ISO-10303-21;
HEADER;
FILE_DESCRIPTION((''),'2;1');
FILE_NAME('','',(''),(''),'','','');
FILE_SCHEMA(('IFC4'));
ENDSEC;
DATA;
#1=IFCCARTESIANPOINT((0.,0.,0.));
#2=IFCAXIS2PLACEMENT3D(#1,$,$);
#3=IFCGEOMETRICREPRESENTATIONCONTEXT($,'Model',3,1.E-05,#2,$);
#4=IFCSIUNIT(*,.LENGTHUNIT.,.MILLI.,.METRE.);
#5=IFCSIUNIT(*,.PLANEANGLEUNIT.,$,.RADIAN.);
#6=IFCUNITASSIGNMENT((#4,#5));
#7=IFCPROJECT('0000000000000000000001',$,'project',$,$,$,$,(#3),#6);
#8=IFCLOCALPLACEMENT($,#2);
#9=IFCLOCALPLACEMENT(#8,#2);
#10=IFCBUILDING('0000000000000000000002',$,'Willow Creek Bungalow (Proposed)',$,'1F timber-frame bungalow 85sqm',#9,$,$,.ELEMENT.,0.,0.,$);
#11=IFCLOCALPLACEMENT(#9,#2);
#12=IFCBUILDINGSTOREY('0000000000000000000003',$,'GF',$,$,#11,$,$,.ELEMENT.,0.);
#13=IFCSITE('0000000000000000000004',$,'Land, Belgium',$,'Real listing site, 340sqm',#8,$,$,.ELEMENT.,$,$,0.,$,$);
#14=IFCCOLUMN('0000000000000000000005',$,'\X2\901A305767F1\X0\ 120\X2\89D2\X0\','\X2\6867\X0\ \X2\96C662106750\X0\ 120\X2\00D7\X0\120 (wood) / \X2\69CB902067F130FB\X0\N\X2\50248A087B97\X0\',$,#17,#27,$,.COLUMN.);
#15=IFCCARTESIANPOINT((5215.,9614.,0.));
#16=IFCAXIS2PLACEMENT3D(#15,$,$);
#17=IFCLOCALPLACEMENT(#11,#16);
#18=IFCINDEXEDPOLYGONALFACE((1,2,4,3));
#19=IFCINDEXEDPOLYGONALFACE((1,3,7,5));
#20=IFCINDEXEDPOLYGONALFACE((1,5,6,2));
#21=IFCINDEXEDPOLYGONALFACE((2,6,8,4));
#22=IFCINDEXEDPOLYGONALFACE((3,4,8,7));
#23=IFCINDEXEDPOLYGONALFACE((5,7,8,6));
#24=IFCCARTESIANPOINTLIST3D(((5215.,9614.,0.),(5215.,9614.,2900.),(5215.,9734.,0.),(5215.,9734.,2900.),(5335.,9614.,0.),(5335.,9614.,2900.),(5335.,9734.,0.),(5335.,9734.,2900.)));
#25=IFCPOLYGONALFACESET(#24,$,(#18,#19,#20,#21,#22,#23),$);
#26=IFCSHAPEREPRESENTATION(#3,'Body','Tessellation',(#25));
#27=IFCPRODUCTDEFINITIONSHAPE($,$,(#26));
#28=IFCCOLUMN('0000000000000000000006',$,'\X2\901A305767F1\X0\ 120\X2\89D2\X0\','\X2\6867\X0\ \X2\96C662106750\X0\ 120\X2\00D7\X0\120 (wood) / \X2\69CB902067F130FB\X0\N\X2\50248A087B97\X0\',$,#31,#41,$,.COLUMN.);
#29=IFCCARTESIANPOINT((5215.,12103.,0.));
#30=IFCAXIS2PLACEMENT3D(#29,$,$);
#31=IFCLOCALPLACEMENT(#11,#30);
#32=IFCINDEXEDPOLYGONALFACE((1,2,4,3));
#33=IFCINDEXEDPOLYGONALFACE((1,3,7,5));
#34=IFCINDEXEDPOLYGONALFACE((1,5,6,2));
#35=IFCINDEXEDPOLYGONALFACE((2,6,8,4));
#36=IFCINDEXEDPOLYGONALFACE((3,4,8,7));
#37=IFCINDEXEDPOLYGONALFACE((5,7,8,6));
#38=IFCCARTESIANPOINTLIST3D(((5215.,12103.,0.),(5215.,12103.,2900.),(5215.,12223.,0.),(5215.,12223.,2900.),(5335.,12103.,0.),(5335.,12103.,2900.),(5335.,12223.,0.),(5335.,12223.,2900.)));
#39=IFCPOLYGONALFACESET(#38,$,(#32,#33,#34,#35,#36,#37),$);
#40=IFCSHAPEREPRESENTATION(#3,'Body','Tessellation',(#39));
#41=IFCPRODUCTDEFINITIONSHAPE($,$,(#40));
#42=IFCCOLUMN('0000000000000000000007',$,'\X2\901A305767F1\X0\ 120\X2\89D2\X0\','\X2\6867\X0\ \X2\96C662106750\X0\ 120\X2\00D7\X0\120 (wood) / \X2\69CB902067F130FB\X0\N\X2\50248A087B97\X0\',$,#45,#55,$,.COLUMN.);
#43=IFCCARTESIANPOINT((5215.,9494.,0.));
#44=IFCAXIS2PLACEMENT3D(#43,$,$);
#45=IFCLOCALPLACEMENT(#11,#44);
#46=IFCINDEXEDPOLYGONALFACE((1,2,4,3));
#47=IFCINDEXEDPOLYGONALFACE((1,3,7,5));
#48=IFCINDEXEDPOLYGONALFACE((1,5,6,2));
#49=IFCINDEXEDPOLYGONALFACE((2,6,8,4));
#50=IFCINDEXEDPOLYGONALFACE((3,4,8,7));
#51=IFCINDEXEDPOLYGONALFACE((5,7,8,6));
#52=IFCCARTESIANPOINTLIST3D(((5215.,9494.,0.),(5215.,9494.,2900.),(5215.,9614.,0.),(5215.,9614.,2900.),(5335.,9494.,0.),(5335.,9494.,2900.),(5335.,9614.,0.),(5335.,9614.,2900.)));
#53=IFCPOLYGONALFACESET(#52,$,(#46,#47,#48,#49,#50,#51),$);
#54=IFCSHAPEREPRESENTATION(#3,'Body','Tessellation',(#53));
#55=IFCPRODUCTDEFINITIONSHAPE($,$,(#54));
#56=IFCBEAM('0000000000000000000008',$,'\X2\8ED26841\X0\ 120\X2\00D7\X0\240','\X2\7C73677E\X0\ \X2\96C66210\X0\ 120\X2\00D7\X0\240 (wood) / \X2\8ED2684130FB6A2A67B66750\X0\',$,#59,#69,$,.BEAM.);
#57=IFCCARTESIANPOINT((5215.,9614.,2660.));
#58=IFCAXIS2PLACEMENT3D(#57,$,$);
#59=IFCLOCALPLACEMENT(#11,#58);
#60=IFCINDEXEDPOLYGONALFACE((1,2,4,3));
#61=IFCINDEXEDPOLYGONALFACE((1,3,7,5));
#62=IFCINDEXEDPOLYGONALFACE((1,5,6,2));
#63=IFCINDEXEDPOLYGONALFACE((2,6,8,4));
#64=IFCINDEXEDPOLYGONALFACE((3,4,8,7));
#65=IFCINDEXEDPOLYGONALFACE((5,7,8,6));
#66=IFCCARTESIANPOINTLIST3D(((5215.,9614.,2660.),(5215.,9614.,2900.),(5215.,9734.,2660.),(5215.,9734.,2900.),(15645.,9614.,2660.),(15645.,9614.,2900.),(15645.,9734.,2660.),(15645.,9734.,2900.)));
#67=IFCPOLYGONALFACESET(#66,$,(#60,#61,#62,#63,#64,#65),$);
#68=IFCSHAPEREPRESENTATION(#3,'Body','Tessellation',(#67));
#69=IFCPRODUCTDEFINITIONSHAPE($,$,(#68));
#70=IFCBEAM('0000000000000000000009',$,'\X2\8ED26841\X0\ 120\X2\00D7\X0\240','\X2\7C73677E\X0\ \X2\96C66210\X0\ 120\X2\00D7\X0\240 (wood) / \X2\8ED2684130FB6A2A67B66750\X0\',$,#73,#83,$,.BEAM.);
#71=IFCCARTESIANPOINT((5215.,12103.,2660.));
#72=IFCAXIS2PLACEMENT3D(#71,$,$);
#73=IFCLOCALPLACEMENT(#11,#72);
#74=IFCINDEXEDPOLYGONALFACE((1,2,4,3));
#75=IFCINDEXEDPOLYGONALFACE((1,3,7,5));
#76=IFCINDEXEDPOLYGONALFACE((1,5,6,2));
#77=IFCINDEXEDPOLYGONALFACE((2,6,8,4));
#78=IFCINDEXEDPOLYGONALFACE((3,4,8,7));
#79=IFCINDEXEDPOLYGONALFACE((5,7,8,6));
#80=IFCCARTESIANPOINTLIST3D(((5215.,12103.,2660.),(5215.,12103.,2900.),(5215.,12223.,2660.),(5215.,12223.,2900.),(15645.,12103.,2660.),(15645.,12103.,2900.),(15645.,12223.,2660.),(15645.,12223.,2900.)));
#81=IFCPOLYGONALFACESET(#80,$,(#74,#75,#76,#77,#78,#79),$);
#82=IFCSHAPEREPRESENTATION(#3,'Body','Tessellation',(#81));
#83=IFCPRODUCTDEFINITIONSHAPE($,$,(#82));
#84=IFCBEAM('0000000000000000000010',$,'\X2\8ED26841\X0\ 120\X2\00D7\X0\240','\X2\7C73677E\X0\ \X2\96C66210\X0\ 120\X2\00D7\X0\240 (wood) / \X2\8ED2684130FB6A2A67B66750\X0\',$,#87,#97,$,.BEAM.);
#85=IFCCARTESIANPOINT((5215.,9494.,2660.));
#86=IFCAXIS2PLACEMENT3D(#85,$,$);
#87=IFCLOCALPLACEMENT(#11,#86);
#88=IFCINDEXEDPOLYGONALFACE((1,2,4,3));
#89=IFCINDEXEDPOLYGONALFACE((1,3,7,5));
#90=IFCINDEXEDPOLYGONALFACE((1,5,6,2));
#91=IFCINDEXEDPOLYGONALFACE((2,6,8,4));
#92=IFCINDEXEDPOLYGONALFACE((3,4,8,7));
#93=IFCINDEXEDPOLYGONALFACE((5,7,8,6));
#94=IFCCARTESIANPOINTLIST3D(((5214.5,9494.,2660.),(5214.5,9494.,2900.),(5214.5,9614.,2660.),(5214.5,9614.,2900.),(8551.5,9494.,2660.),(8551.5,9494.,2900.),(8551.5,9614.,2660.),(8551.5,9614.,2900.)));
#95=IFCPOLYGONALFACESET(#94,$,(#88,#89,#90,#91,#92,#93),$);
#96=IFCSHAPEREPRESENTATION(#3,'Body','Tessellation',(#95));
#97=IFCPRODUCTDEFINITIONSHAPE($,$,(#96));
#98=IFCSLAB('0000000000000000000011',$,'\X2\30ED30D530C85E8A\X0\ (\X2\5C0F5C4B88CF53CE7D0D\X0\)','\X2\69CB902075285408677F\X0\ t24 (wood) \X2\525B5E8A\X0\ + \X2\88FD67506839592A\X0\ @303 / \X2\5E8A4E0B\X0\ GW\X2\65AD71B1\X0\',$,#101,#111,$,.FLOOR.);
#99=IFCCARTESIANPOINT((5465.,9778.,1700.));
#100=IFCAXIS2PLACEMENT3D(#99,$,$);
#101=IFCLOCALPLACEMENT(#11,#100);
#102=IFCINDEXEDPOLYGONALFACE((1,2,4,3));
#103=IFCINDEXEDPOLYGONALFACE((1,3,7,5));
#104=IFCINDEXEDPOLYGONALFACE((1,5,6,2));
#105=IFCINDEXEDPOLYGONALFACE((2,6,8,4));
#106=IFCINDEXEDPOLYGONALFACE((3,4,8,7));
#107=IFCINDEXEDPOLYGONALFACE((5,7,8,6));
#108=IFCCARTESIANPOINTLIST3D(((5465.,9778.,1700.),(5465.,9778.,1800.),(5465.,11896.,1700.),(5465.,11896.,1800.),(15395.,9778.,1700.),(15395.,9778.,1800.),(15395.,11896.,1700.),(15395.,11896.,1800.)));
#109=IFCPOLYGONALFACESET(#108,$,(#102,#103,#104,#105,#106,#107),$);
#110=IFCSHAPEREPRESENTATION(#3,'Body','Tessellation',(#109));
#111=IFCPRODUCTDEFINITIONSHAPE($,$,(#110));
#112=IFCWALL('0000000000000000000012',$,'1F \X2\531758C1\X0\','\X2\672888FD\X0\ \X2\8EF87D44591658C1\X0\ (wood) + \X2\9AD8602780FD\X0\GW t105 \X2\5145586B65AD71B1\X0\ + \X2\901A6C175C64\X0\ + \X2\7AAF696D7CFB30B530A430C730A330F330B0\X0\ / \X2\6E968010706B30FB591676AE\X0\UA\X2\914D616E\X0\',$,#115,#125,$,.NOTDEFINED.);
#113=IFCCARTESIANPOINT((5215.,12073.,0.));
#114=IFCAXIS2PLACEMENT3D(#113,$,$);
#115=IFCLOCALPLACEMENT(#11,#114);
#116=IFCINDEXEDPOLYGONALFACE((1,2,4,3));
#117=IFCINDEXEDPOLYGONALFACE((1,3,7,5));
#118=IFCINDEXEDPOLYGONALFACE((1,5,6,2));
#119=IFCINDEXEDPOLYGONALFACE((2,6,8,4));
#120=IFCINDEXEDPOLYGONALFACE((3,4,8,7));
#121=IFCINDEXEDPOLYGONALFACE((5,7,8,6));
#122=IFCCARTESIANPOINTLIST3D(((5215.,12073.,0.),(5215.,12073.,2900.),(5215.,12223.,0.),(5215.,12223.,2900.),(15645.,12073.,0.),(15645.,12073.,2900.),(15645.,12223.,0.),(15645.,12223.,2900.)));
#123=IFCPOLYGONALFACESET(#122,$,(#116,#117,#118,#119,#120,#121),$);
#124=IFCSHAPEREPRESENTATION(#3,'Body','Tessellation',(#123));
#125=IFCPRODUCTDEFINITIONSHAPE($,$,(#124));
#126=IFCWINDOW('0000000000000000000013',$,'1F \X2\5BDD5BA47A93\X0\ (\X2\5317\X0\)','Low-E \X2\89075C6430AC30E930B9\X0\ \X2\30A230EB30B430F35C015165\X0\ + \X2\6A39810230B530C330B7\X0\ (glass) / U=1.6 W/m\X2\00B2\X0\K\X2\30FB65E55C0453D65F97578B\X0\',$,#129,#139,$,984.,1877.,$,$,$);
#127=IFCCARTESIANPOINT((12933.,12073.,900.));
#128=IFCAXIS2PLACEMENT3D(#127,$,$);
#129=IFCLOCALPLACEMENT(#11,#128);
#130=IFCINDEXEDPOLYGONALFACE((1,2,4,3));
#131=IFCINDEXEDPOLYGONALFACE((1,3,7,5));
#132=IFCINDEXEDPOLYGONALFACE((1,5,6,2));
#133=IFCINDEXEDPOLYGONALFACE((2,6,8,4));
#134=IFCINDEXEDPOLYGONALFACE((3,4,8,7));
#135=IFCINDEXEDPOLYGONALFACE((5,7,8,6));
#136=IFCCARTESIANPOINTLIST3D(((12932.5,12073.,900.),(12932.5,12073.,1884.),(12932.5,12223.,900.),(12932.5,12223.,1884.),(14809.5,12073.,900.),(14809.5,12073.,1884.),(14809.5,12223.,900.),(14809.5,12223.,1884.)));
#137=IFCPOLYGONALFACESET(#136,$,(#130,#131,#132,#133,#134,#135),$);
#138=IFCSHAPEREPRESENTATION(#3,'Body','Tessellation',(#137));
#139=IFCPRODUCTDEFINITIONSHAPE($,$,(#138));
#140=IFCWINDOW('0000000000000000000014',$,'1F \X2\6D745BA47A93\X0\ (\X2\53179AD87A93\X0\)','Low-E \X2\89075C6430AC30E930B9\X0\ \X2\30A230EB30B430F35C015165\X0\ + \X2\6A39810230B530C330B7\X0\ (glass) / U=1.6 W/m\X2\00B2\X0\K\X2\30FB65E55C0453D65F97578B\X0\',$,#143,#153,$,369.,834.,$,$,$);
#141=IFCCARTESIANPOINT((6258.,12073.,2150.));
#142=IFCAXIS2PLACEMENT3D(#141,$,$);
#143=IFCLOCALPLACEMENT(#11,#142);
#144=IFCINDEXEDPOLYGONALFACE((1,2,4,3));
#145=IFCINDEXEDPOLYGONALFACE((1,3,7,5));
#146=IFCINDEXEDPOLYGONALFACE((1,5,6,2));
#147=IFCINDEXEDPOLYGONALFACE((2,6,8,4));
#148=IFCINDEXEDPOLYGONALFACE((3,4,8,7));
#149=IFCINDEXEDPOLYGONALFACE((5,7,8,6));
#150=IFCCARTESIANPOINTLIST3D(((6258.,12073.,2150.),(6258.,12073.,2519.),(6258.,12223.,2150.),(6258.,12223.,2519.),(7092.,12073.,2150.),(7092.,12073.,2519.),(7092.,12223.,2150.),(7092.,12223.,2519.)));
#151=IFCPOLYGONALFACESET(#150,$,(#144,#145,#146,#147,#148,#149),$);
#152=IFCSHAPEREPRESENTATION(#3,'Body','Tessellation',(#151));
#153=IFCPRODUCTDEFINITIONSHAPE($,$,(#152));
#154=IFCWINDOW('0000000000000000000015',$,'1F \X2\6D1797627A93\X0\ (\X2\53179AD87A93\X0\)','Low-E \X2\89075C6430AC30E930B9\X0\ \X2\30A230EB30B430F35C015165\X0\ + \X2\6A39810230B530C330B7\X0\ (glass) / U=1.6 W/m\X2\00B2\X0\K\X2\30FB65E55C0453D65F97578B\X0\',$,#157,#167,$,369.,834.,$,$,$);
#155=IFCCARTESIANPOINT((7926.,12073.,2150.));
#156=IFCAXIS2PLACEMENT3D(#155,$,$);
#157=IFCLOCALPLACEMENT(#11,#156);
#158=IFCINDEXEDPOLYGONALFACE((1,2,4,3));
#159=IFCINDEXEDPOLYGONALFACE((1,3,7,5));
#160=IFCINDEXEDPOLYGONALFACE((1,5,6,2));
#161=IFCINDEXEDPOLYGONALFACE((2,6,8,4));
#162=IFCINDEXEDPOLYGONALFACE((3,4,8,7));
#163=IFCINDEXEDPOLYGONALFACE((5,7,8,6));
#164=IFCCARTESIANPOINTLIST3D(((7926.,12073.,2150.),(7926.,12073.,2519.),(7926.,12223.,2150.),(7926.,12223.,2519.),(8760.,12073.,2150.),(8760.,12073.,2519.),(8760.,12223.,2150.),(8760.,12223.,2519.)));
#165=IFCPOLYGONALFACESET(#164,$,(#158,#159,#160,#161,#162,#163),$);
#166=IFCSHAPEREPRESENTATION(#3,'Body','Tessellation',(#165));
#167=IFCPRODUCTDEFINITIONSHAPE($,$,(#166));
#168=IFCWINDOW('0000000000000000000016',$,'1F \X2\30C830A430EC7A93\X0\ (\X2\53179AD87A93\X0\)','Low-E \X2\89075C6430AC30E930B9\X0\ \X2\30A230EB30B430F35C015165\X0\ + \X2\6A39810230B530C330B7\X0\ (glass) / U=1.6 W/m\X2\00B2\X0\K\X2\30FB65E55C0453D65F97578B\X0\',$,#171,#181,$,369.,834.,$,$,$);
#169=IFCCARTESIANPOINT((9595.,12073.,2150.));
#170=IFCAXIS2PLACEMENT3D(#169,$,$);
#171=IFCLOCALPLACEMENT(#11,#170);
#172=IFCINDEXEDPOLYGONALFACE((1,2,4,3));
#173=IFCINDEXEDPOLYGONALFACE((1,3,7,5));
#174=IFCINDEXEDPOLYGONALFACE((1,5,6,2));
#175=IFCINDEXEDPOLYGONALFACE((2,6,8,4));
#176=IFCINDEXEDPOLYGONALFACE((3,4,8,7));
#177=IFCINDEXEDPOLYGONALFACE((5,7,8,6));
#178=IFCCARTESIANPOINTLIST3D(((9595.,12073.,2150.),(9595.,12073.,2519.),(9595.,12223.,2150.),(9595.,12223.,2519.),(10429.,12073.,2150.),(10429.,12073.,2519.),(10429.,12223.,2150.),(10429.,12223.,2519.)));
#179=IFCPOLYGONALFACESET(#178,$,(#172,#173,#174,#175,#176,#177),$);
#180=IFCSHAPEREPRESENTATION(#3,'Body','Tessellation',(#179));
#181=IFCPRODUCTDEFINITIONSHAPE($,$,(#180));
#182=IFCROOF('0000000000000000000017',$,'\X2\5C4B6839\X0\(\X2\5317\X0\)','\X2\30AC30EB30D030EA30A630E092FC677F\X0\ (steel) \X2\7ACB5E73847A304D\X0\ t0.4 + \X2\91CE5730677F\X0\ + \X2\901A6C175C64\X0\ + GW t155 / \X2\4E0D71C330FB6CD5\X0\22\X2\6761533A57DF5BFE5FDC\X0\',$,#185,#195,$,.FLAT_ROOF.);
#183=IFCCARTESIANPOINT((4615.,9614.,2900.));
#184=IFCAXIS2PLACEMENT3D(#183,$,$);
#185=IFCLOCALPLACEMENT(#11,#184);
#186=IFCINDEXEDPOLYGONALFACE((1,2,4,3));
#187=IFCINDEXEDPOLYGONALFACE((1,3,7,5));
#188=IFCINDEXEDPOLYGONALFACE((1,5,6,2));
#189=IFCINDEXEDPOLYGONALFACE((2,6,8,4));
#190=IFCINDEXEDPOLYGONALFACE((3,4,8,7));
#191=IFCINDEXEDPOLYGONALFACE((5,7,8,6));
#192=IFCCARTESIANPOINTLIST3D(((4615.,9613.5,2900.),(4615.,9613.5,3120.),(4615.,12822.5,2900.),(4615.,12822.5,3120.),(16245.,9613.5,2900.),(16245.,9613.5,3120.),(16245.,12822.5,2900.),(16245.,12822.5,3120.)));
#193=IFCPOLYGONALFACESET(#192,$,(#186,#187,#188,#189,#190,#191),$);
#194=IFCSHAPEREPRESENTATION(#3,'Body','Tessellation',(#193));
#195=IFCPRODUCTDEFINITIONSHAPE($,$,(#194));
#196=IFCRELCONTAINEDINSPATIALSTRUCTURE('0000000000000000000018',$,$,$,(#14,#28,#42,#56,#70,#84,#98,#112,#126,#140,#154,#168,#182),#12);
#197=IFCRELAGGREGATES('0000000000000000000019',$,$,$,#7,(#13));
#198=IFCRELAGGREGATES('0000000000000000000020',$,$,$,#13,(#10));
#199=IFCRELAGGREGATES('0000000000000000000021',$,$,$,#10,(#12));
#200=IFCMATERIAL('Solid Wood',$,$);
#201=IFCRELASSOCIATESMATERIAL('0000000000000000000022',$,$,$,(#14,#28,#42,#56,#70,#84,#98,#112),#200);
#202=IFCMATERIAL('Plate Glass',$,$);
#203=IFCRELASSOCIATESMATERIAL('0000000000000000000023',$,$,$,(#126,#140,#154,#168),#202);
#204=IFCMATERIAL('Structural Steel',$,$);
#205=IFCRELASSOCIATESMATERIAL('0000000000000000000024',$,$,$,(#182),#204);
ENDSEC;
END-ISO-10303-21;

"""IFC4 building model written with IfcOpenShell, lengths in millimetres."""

from ifc_helpers import new_model, si_unit, frame, frame_2d, origin, place, context, project, spatial, rectangle, extrude, material, element, fill, save


model = new_model("IFC4")

# Units and contexts
model_context = context("Model", 3, precision=1e-05, world=origin())
ifc_project = project(units=[si_unit("LENGTHUNIT", "METRE", prefix="MILLI"), si_unit("PLANEANGLEUNIT", "RADIAN")], contexts=[model_context])

# Site, building, storey
site_placement = place(None, origin())
site = spatial("IfcSite", under=ifc_project, at=site_placement, Name="Land, Belgium", ObjectType="Real listing site, 340sqm", CompositionType="ELEMENT", RefElevation=0.0)
building_placement = place(site_placement, origin())
building = spatial("IfcBuilding", under=site, at=building_placement, Name="Willow Creek Bungalow (Proposed)", ObjectType="1F timber-frame bungalow 85sqm", CompositionType="ELEMENT", ElevationOfRefHeight=0.0, ElevationOfTerrain=0.0)
storey_placement = place(building_placement, origin())
storey = spatial("IfcBuildingStorey", under=building, at=storey_placement, Name="GF", CompositionType="ELEMENT", Elevation=0.0)

# Columns
ifc_material_1 = material(Name="Solid Wood")
column_1_placement = place(storey_placement, frame((5215.0, 9614.0, 0.0)))
element("IfcColumn", 1, at=column_1_placement, inside=storey, material=ifc_material_1, Name="通し柱 120角", Description="桧 集成材 120×120 (wood) / 構造柱・N値計算", PredefinedType="COLUMN", context=model_context, shape_type="SweptSolid", body=[
    extrude(rectangle(XDim=120.0, YDim=120.0, at=frame_2d((60.0, 60.0))), frame((5215.0, 9614.0, 0.0)), (0.0, 0.0, 1.0), 2900.0),
])
column_2_placement = place(storey_placement, frame((5215.0, 12103.0, 0.0)))
element("IfcColumn", 2, at=column_2_placement, inside=storey, material=ifc_material_1, Name="通し柱 120角", Description="桧 集成材 120×120 (wood) / 構造柱・N値計算", PredefinedType="COLUMN", context=model_context, shape_type="SweptSolid", body=[
    extrude(rectangle(XDim=120.0, YDim=120.0, at=frame_2d((60.0, 60.0))), frame((5215.0, 12103.0, 0.0)), (0.0, 0.0, 1.0), 2900.0),
])
column_3_placement = place(storey_placement, frame((5215.0, 9494.0, 0.0)))
element("IfcColumn", 3, at=column_3_placement, inside=storey, material=ifc_material_1, Name="通し柱 120角", Description="桧 集成材 120×120 (wood) / 構造柱・N値計算", PredefinedType="COLUMN", context=model_context, shape_type="SweptSolid", body=[
    extrude(rectangle(XDim=120.0, YDim=120.0, at=frame_2d((60.0, 60.0))), frame((5215.0, 9494.0, 0.0)), (0.0, 0.0, 1.0), 2900.0),
])

# Beams
beam_1_placement = place(storey_placement, frame((5215.0, 9614.0, 2660.0)))
element("IfcBeam", 4, at=beam_1_placement, inside=storey, material=ifc_material_1, Name="軒桁 120×240", Description="米松 集成 120×240 (wood) / 軒桁・横架材", PredefinedType="BEAM", context=model_context, shape_type="SweptSolid", body=[
    extrude(rectangle(XDim=10430.0, YDim=120.0, at=frame_2d((5215.0, 60.0))), frame((5215.0, 9614.0, 2660.0)), (0.0, 0.0, 1.0), 240.0),
])
beam_2_placement = place(storey_placement, frame((5215.0, 12103.0, 2660.0)))
element("IfcBeam", 5, at=beam_2_placement, inside=storey, material=ifc_material_1, Name="軒桁 120×240", Description="米松 集成 120×240 (wood) / 軒桁・横架材", PredefinedType="BEAM", context=model_context, shape_type="SweptSolid", body=[
    extrude(rectangle(XDim=10430.0, YDim=120.0, at=frame_2d((5215.0, 60.0))), frame((5215.0, 12103.0, 2660.0)), (0.0, 0.0, 1.0), 240.0),
])
beam_3_placement = place(storey_placement, frame((5215.0, 9494.0, 2660.0)))
element("IfcBeam", 6, at=beam_3_placement, inside=storey, material=ifc_material_1, Name="軒桁 120×240", Description="米松 集成 120×240 (wood) / 軒桁・横架材", PredefinedType="BEAM", context=model_context, shape_type="SweptSolid", body=[
    extrude(rectangle(XDim=3337.0, YDim=120.0, at=frame_2d((1668.0, 60.0))), frame((5215.0, 9494.0, 2660.0)), (0.0, 0.0, 1.0), 240.0),
])

# Slab
slab_1_placement = place(storey_placement, frame((5465.0, 9778.0, 1700.0)))
element("IfcSlab", 7, at=slab_1_placement, inside=storey, material=ifc_material_1, Name="ロフト床 (小屋裏収納)", Description="構造用合板 t24 (wood) 剛床 + 製材根太 @303 / 床下 GW断熱", PredefinedType="FLOOR", context=model_context, shape_type="SweptSolid", body=[
    extrude(rectangle(XDim=9930.0, YDim=2118.0, at=frame_2d((4965.0, 1059.0))), frame((5465.0, 9778.0, 1700.0)), (0.0, 0.0, 1.0), 100.0),
])

# Wall, openings, windows
wall_1_placement = place(storey_placement, frame((5215.0, 12073.0, 0.0)))
wall_1 = element("IfcWall", 8, at=wall_1_placement, inside=storey, material=ifc_material_1, Name="1F 北壁", Description="木製 軸組外壁 (wood) + 高性能GW t105 充填断熱 + 通気層 + 窯業系サイディング / 準耐火・外皮UA配慮", PredefinedType="NOTDEFINED", context=model_context, shape_type="SweptSolid", body=[
    extrude(rectangle(XDim=10430.0, YDim=150.0, at=frame_2d((5215.0, 75.0))), frame((5215.0, 12073.0, 0.0)), (0.0, 0.0, 1.0), 2900.0),
])
opening_1_placement = place(storey_placement, frame((12933.0, 12073.0, 900.0)))
opening_1 = element("IfcOpeningElement", 9, at=opening_1_placement, cuts=wall_1, PredefinedType="NOTDEFINED", context=model_context, shape_type="SweptSolid", body=[
    extrude(rectangle(XDim=1877.0, YDim=150.0, at=frame_2d((938.0, 75.0))), frame((12933.0, 12073.0, 900.0)), (0.0, 0.0, 1.0), 984.0),
])
opening_2_placement = place(storey_placement, frame((6258.0, 12073.0, 2150.0)))
opening_2 = element("IfcOpeningElement", 10, at=opening_2_placement, cuts=wall_1, PredefinedType="NOTDEFINED", context=model_context, shape_type="SweptSolid", body=[
    extrude(rectangle(XDim=834.0, YDim=150.0, at=frame_2d((417.0, 75.0))), frame((6258.0, 12073.0, 2150.0)), (0.0, 0.0, 1.0), 369.0),
])
opening_3_placement = place(storey_placement, frame((7926.0, 12073.0, 2150.0)))
opening_3 = element("IfcOpeningElement", 11, at=opening_3_placement, cuts=wall_1, PredefinedType="NOTDEFINED", context=model_context, shape_type="SweptSolid", body=[
    extrude(rectangle(XDim=834.0, YDim=150.0, at=frame_2d((417.0, 75.0))), frame((7926.0, 12073.0, 2150.0)), (0.0, 0.0, 1.0), 369.0),
])
opening_4_placement = place(storey_placement, frame((9595.0, 12073.0, 2150.0)))
opening_4 = element("IfcOpeningElement", 12, at=opening_4_placement, cuts=wall_1, PredefinedType="NOTDEFINED", context=model_context, shape_type="SweptSolid", body=[
    extrude(rectangle(XDim=834.0, YDim=150.0, at=frame_2d((417.0, 75.0))), frame((9595.0, 12073.0, 2150.0)), (0.0, 0.0, 1.0), 369.0),
])
ifc_material_2 = material(Name="Plate Glass")
window_1_placement = place(storey_placement, frame((12933.0, 12073.0, 900.0)))
window_1 = element("IfcWindow", 13, at=window_1_placement, inside=storey, material=ifc_material_2, Name="1F 寝室窓 (北)", Description="Low-E 複層ガラス アルゴン封入 + 樹脂サッシ (glass) / U=1.6 W/m²K・日射取得型", OverallHeight=984.0, OverallWidth=1877.0, context=model_context, shape_type="SweptSolid", body=[
    extrude(rectangle(XDim=1877.0, YDim=150.0, at=frame_2d((938.0, 75.0))), frame((12933.0, 12073.0, 900.0)), (0.0, 0.0, 1.0), 984.0),
])
fill(opening_1, window_1)
window_2_placement = place(storey_placement, frame((6258.0, 12073.0, 2150.0)))
window_2 = element("IfcWindow", 14, at=window_2_placement, inside=storey, material=ifc_material_2, Name="1F 浴室窓 (北高窓)", Description="Low-E 複層ガラス アルゴン封入 + 樹脂サッシ (glass) / U=1.6 W/m²K・日射取得型", OverallHeight=369.0, OverallWidth=834.0, context=model_context, shape_type="SweptSolid", body=[
    extrude(rectangle(XDim=834.0, YDim=150.0, at=frame_2d((417.0, 75.0))), frame((6258.0, 12073.0, 2150.0)), (0.0, 0.0, 1.0), 369.0),
])
fill(opening_2, window_2)
window_3_placement = place(storey_placement, frame((7926.0, 12073.0, 2150.0)))
window_3 = element("IfcWindow", 15, at=window_3_placement, inside=storey, material=ifc_material_2, Name="1F 洗面窓 (北高窓)", Description="Low-E 複層ガラス アルゴン封入 + 樹脂サッシ (glass) / U=1.6 W/m²K・日射取得型", OverallHeight=369.0, OverallWidth=834.0, context=model_context, shape_type="SweptSolid", body=[
    extrude(rectangle(XDim=834.0, YDim=150.0, at=frame_2d((417.0, 75.0))), frame((7926.0, 12073.0, 2150.0)), (0.0, 0.0, 1.0), 369.0),
])
fill(opening_3, window_3)
window_4_placement = place(storey_placement, frame((9595.0, 12073.0, 2150.0)))
window_4 = element("IfcWindow", 16, at=window_4_placement, inside=storey, material=ifc_material_2, Name="1F トイレ窓 (北高窓)", Description="Low-E 複層ガラス アルゴン封入 + 樹脂サッシ (glass) / U=1.6 W/m²K・日射取得型", OverallHeight=369.0, OverallWidth=834.0, context=model_context, shape_type="SweptSolid", body=[
    extrude(rectangle(XDim=834.0, YDim=150.0, at=frame_2d((417.0, 75.0))), frame((9595.0, 12073.0, 2150.0)), (0.0, 0.0, 1.0), 369.0),
])
fill(opening_4, window_4)

# Roof
ifc_material_3 = material(Name="Structural Steel")
roof_placement = place(storey_placement, frame((4615.0, 9614.0, 2900.0)))
element("IfcRoof", 17, at=roof_placement, inside=storey, material=ifc_material_3, Name="屋根(北)", Description="ガルバリウム鋼板 (steel) 立平葺き t0.4 + 野地板 + 通気層 + GW t155 / 不燃・法22条区域対応", PredefinedType="FLAT_ROOF", context=model_context, shape_type="SweptSolid", body=[
    extrude(rectangle(XDim=11630.0, YDim=3209.0, at=frame_2d((5815.0, 1604.0))), frame((4615.0, 9614.0, 2900.0)), (0.0, 0.0, 1.0), 220.0),
])

save(model, "model.ifc")
